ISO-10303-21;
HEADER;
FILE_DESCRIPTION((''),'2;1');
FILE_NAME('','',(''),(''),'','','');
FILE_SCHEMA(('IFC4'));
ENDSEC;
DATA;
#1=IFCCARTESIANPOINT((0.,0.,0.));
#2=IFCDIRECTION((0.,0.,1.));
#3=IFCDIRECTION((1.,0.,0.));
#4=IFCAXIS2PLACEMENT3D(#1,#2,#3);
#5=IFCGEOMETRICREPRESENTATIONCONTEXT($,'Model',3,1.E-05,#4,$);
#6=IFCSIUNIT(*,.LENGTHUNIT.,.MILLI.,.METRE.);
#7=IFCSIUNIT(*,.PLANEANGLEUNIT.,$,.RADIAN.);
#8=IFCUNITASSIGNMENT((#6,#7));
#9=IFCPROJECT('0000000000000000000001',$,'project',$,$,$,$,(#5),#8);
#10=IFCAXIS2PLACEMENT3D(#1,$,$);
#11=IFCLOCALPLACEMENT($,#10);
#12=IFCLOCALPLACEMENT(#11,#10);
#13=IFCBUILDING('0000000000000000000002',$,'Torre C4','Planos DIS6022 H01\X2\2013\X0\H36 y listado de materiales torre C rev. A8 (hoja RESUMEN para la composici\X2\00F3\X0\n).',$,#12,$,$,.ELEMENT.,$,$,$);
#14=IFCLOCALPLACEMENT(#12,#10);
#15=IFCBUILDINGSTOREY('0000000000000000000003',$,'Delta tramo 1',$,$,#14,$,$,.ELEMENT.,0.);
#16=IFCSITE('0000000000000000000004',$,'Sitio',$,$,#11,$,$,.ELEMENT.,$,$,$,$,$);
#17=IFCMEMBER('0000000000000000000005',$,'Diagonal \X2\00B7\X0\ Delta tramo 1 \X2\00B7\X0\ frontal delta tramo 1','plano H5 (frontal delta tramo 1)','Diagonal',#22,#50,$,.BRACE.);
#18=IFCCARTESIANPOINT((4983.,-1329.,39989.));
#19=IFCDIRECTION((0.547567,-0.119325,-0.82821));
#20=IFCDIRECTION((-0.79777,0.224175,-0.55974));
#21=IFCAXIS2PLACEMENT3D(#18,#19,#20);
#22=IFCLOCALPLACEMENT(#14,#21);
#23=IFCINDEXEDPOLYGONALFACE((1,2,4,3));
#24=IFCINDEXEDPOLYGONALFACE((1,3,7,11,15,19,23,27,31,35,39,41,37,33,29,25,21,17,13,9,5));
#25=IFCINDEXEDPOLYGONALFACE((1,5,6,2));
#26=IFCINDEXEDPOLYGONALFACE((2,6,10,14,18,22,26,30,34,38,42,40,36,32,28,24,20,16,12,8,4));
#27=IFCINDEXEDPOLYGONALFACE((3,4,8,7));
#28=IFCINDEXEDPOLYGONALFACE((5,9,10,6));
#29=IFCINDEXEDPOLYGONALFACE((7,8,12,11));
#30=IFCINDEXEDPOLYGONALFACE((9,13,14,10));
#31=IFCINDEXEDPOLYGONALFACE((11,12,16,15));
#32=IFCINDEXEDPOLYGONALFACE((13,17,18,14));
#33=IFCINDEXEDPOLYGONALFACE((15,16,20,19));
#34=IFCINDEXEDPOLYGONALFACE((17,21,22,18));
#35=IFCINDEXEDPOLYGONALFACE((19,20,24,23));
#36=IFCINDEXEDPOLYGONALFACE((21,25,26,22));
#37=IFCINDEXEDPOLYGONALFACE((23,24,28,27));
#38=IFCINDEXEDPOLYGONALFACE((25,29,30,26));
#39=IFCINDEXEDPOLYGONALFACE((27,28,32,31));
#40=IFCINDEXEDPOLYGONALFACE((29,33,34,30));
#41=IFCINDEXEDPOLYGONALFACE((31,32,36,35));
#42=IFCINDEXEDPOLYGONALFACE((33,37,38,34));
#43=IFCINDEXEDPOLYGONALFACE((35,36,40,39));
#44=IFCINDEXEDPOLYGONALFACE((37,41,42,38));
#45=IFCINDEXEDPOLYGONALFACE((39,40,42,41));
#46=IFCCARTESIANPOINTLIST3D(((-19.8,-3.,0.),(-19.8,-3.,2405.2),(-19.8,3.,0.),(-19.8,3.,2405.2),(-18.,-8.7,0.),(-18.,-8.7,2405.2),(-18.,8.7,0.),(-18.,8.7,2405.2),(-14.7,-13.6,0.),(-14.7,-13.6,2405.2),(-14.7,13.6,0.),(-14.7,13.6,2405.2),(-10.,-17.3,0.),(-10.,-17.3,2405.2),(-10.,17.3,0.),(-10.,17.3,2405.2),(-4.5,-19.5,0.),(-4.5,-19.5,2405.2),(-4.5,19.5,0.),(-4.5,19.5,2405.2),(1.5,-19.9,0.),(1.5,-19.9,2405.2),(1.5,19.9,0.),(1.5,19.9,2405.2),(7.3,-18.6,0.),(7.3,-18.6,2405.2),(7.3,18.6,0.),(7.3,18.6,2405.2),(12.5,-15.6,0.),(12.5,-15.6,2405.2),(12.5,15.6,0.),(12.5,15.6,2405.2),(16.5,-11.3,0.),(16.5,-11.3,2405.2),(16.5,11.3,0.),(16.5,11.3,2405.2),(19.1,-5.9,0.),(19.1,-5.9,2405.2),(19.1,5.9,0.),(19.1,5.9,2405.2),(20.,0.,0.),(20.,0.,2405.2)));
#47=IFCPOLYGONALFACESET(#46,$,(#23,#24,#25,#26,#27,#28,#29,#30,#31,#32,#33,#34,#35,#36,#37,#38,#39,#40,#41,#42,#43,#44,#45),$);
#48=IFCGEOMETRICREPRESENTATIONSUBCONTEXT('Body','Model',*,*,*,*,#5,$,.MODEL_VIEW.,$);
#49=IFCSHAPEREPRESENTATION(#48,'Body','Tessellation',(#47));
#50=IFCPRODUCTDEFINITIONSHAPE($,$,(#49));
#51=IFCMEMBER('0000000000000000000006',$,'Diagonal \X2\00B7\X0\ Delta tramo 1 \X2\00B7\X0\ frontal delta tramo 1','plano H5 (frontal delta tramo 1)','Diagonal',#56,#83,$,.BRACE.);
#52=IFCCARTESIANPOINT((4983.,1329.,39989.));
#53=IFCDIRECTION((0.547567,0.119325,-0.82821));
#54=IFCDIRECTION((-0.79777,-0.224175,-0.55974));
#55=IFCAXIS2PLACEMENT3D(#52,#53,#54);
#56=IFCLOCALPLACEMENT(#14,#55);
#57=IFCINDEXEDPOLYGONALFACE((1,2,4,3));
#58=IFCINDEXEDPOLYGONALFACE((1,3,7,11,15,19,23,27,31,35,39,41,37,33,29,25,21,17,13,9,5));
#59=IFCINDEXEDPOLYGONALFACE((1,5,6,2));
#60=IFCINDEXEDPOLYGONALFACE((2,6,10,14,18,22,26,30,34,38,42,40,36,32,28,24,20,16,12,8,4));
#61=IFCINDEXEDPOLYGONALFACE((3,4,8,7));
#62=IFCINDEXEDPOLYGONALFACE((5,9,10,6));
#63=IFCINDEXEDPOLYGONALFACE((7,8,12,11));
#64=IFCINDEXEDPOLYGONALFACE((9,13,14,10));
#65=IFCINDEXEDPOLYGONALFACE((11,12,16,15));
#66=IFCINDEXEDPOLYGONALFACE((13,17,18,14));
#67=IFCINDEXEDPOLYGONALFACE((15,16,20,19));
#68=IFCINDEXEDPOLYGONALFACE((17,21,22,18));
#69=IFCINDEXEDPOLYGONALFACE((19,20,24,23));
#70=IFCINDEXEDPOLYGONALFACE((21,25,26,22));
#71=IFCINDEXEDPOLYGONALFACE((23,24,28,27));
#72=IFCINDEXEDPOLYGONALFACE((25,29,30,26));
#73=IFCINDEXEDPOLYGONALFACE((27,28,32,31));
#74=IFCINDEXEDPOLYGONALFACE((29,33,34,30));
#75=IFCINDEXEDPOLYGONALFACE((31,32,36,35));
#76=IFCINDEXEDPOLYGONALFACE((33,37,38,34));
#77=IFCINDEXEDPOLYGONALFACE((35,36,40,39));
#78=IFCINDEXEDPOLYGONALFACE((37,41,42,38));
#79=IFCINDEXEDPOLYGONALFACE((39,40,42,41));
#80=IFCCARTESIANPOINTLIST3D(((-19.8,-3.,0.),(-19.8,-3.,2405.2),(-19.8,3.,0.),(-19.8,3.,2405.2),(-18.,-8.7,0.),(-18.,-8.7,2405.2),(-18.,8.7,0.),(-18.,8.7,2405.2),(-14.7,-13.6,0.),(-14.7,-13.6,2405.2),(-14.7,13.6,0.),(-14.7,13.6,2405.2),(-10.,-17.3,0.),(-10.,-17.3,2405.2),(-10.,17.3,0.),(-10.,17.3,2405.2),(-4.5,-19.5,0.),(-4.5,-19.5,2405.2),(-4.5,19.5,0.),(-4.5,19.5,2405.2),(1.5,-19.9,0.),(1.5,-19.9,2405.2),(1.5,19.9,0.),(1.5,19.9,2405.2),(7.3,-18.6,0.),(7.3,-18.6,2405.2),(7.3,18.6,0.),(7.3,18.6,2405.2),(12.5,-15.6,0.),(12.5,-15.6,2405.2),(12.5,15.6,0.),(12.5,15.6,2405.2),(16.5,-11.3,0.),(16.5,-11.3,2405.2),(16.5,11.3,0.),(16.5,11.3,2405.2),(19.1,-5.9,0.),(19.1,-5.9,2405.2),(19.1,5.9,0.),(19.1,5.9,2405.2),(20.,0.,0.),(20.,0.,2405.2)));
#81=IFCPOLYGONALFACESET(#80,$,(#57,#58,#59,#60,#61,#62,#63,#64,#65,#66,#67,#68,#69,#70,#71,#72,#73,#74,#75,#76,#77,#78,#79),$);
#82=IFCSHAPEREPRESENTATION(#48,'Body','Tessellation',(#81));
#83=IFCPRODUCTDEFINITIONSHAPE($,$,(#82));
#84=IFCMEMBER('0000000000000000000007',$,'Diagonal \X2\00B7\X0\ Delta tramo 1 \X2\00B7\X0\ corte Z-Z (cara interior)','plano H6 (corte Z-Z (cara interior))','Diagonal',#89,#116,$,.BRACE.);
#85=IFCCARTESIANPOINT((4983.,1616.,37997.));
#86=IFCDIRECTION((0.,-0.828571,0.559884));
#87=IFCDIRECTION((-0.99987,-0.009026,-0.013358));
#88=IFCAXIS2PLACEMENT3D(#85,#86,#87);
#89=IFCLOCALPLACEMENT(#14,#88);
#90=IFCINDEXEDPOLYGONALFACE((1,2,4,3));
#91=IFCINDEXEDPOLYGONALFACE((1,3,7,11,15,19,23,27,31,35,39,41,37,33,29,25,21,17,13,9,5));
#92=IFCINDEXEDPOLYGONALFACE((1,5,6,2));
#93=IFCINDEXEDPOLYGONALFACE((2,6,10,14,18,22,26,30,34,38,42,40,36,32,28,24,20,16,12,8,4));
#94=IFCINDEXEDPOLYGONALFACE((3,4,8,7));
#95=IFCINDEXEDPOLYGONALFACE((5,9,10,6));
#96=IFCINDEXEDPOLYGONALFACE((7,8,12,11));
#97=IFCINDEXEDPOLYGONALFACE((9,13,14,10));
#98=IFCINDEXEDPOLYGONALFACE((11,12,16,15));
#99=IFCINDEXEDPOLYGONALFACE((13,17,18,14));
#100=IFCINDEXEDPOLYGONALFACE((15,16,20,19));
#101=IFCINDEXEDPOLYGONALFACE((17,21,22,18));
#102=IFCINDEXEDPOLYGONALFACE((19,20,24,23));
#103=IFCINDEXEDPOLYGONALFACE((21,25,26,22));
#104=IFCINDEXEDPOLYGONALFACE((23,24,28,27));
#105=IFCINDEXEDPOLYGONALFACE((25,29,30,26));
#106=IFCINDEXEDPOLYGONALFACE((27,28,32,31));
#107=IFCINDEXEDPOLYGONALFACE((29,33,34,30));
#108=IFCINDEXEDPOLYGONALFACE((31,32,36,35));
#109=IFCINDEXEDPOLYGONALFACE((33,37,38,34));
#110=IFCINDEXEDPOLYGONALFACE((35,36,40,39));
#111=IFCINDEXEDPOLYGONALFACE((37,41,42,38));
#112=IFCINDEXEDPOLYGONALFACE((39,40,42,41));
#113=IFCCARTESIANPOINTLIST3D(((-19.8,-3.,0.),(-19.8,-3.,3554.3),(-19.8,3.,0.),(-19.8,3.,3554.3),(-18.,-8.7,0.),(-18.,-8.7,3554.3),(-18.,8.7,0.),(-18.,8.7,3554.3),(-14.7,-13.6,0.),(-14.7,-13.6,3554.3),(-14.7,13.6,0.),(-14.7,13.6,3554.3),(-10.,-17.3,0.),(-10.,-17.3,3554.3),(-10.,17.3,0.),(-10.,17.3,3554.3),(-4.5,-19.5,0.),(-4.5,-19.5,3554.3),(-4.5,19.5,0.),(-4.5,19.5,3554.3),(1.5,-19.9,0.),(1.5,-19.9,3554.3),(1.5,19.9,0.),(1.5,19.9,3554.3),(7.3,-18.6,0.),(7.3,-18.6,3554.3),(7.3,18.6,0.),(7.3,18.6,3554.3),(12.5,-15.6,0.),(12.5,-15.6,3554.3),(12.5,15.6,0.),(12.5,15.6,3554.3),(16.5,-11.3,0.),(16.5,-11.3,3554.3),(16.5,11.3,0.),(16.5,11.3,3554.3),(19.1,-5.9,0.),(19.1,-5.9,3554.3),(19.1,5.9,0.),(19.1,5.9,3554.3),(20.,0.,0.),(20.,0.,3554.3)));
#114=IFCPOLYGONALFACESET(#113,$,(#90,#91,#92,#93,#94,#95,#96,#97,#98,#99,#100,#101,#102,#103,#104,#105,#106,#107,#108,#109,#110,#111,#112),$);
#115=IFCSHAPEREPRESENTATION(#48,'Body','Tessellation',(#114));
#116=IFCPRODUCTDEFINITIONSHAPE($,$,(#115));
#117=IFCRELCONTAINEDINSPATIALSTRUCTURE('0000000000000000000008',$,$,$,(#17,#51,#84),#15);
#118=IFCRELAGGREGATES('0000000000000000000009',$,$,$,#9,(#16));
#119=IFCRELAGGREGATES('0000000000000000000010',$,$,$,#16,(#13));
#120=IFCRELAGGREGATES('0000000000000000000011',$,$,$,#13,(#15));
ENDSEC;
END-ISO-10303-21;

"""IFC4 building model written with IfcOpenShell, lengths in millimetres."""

from ifc_helpers import new_model, si_unit, frame, origin, origin_with_axes, place, context, subcontext, project, spatial, circle, extrude, element, save


model = new_model("IFC4")

# Units and contexts
model_context = context("Model", 3, precision=1e-05, world=origin_with_axes())
body_context = subcontext(model_context, "Body", "Model", "MODEL_VIEW")
ifc_project = project(units=[si_unit("LENGTHUNIT", "METRE", prefix="MILLI"), si_unit("PLANEANGLEUNIT", "RADIAN")], contexts=[model_context])

# Site, building, storey
site_placement = place(None, origin())
site = spatial("IfcSite", under=ifc_project, at=site_placement, Name="Sitio", CompositionType="ELEMENT")
building_placement = place(site_placement, origin())
building = spatial("IfcBuilding", under=site, at=building_placement, Name="Torre C4", Description="Planos DIS6022 H01–H36 y listado de materiales torre C rev. A8 (hoja RESUMEN para la composición).", CompositionType="ELEMENT")
storey_placement = place(building_placement, origin())
storey = spatial("IfcBuildingStorey", under=building, at=storey_placement, Name="Delta tramo 1", CompositionType="ELEMENT", Elevation=0.0)

# Members
for number, where, z_axis, x_axis, name in (
    (1, (4983.0, -1329.0, 39989.0), (0.547567, -0.119325, -0.82821), (-0.79777, 0.224175, -0.55974), "Diagonal · Delta tramo 1 · frontal delta tramo 1"),
    (2, (4983.0, 1329.0, 39989.0), (0.547567, 0.119325, -0.82821), (-0.79777, -0.224175, -0.55974), "Diagonal · Delta tramo 1 · frontal delta tramo 1"),
):
    element("IfcMember", number, at=place(storey_placement, frame(where, z_axis=z_axis, x_axis=x_axis)), inside=storey, Name=name, Description="plano H5 (frontal delta tramo 1)", ObjectType="Diagonal", PredefinedType="BRACE", context=body_context, shape_type="SweptSolid", body=[
        extrude(circle(Radius=20.0), None, (0.0, 0.0, 1.0), 2405.2),
    ])
member_1_placement = place(storey_placement, frame((4983.0, 1616.0, 37997.0), z_axis=(0.0, -0.828571, 0.559884), x_axis=(-0.99987, -0.009026, -0.013358)))
element("IfcMember", 3, at=member_1_placement, inside=storey, Name="Diagonal · Delta tramo 1 · corte Z-Z (cara interior)", Description="plano H6 (corte Z-Z (cara interior))", ObjectType="Diagonal", PredefinedType="BRACE", context=body_context, shape_type="SweptSolid", body=[
    extrude(circle(Radius=20.0), None, (0.0, 0.0, 1.0), 3554.3),
])

save(model, "model.ifc")
